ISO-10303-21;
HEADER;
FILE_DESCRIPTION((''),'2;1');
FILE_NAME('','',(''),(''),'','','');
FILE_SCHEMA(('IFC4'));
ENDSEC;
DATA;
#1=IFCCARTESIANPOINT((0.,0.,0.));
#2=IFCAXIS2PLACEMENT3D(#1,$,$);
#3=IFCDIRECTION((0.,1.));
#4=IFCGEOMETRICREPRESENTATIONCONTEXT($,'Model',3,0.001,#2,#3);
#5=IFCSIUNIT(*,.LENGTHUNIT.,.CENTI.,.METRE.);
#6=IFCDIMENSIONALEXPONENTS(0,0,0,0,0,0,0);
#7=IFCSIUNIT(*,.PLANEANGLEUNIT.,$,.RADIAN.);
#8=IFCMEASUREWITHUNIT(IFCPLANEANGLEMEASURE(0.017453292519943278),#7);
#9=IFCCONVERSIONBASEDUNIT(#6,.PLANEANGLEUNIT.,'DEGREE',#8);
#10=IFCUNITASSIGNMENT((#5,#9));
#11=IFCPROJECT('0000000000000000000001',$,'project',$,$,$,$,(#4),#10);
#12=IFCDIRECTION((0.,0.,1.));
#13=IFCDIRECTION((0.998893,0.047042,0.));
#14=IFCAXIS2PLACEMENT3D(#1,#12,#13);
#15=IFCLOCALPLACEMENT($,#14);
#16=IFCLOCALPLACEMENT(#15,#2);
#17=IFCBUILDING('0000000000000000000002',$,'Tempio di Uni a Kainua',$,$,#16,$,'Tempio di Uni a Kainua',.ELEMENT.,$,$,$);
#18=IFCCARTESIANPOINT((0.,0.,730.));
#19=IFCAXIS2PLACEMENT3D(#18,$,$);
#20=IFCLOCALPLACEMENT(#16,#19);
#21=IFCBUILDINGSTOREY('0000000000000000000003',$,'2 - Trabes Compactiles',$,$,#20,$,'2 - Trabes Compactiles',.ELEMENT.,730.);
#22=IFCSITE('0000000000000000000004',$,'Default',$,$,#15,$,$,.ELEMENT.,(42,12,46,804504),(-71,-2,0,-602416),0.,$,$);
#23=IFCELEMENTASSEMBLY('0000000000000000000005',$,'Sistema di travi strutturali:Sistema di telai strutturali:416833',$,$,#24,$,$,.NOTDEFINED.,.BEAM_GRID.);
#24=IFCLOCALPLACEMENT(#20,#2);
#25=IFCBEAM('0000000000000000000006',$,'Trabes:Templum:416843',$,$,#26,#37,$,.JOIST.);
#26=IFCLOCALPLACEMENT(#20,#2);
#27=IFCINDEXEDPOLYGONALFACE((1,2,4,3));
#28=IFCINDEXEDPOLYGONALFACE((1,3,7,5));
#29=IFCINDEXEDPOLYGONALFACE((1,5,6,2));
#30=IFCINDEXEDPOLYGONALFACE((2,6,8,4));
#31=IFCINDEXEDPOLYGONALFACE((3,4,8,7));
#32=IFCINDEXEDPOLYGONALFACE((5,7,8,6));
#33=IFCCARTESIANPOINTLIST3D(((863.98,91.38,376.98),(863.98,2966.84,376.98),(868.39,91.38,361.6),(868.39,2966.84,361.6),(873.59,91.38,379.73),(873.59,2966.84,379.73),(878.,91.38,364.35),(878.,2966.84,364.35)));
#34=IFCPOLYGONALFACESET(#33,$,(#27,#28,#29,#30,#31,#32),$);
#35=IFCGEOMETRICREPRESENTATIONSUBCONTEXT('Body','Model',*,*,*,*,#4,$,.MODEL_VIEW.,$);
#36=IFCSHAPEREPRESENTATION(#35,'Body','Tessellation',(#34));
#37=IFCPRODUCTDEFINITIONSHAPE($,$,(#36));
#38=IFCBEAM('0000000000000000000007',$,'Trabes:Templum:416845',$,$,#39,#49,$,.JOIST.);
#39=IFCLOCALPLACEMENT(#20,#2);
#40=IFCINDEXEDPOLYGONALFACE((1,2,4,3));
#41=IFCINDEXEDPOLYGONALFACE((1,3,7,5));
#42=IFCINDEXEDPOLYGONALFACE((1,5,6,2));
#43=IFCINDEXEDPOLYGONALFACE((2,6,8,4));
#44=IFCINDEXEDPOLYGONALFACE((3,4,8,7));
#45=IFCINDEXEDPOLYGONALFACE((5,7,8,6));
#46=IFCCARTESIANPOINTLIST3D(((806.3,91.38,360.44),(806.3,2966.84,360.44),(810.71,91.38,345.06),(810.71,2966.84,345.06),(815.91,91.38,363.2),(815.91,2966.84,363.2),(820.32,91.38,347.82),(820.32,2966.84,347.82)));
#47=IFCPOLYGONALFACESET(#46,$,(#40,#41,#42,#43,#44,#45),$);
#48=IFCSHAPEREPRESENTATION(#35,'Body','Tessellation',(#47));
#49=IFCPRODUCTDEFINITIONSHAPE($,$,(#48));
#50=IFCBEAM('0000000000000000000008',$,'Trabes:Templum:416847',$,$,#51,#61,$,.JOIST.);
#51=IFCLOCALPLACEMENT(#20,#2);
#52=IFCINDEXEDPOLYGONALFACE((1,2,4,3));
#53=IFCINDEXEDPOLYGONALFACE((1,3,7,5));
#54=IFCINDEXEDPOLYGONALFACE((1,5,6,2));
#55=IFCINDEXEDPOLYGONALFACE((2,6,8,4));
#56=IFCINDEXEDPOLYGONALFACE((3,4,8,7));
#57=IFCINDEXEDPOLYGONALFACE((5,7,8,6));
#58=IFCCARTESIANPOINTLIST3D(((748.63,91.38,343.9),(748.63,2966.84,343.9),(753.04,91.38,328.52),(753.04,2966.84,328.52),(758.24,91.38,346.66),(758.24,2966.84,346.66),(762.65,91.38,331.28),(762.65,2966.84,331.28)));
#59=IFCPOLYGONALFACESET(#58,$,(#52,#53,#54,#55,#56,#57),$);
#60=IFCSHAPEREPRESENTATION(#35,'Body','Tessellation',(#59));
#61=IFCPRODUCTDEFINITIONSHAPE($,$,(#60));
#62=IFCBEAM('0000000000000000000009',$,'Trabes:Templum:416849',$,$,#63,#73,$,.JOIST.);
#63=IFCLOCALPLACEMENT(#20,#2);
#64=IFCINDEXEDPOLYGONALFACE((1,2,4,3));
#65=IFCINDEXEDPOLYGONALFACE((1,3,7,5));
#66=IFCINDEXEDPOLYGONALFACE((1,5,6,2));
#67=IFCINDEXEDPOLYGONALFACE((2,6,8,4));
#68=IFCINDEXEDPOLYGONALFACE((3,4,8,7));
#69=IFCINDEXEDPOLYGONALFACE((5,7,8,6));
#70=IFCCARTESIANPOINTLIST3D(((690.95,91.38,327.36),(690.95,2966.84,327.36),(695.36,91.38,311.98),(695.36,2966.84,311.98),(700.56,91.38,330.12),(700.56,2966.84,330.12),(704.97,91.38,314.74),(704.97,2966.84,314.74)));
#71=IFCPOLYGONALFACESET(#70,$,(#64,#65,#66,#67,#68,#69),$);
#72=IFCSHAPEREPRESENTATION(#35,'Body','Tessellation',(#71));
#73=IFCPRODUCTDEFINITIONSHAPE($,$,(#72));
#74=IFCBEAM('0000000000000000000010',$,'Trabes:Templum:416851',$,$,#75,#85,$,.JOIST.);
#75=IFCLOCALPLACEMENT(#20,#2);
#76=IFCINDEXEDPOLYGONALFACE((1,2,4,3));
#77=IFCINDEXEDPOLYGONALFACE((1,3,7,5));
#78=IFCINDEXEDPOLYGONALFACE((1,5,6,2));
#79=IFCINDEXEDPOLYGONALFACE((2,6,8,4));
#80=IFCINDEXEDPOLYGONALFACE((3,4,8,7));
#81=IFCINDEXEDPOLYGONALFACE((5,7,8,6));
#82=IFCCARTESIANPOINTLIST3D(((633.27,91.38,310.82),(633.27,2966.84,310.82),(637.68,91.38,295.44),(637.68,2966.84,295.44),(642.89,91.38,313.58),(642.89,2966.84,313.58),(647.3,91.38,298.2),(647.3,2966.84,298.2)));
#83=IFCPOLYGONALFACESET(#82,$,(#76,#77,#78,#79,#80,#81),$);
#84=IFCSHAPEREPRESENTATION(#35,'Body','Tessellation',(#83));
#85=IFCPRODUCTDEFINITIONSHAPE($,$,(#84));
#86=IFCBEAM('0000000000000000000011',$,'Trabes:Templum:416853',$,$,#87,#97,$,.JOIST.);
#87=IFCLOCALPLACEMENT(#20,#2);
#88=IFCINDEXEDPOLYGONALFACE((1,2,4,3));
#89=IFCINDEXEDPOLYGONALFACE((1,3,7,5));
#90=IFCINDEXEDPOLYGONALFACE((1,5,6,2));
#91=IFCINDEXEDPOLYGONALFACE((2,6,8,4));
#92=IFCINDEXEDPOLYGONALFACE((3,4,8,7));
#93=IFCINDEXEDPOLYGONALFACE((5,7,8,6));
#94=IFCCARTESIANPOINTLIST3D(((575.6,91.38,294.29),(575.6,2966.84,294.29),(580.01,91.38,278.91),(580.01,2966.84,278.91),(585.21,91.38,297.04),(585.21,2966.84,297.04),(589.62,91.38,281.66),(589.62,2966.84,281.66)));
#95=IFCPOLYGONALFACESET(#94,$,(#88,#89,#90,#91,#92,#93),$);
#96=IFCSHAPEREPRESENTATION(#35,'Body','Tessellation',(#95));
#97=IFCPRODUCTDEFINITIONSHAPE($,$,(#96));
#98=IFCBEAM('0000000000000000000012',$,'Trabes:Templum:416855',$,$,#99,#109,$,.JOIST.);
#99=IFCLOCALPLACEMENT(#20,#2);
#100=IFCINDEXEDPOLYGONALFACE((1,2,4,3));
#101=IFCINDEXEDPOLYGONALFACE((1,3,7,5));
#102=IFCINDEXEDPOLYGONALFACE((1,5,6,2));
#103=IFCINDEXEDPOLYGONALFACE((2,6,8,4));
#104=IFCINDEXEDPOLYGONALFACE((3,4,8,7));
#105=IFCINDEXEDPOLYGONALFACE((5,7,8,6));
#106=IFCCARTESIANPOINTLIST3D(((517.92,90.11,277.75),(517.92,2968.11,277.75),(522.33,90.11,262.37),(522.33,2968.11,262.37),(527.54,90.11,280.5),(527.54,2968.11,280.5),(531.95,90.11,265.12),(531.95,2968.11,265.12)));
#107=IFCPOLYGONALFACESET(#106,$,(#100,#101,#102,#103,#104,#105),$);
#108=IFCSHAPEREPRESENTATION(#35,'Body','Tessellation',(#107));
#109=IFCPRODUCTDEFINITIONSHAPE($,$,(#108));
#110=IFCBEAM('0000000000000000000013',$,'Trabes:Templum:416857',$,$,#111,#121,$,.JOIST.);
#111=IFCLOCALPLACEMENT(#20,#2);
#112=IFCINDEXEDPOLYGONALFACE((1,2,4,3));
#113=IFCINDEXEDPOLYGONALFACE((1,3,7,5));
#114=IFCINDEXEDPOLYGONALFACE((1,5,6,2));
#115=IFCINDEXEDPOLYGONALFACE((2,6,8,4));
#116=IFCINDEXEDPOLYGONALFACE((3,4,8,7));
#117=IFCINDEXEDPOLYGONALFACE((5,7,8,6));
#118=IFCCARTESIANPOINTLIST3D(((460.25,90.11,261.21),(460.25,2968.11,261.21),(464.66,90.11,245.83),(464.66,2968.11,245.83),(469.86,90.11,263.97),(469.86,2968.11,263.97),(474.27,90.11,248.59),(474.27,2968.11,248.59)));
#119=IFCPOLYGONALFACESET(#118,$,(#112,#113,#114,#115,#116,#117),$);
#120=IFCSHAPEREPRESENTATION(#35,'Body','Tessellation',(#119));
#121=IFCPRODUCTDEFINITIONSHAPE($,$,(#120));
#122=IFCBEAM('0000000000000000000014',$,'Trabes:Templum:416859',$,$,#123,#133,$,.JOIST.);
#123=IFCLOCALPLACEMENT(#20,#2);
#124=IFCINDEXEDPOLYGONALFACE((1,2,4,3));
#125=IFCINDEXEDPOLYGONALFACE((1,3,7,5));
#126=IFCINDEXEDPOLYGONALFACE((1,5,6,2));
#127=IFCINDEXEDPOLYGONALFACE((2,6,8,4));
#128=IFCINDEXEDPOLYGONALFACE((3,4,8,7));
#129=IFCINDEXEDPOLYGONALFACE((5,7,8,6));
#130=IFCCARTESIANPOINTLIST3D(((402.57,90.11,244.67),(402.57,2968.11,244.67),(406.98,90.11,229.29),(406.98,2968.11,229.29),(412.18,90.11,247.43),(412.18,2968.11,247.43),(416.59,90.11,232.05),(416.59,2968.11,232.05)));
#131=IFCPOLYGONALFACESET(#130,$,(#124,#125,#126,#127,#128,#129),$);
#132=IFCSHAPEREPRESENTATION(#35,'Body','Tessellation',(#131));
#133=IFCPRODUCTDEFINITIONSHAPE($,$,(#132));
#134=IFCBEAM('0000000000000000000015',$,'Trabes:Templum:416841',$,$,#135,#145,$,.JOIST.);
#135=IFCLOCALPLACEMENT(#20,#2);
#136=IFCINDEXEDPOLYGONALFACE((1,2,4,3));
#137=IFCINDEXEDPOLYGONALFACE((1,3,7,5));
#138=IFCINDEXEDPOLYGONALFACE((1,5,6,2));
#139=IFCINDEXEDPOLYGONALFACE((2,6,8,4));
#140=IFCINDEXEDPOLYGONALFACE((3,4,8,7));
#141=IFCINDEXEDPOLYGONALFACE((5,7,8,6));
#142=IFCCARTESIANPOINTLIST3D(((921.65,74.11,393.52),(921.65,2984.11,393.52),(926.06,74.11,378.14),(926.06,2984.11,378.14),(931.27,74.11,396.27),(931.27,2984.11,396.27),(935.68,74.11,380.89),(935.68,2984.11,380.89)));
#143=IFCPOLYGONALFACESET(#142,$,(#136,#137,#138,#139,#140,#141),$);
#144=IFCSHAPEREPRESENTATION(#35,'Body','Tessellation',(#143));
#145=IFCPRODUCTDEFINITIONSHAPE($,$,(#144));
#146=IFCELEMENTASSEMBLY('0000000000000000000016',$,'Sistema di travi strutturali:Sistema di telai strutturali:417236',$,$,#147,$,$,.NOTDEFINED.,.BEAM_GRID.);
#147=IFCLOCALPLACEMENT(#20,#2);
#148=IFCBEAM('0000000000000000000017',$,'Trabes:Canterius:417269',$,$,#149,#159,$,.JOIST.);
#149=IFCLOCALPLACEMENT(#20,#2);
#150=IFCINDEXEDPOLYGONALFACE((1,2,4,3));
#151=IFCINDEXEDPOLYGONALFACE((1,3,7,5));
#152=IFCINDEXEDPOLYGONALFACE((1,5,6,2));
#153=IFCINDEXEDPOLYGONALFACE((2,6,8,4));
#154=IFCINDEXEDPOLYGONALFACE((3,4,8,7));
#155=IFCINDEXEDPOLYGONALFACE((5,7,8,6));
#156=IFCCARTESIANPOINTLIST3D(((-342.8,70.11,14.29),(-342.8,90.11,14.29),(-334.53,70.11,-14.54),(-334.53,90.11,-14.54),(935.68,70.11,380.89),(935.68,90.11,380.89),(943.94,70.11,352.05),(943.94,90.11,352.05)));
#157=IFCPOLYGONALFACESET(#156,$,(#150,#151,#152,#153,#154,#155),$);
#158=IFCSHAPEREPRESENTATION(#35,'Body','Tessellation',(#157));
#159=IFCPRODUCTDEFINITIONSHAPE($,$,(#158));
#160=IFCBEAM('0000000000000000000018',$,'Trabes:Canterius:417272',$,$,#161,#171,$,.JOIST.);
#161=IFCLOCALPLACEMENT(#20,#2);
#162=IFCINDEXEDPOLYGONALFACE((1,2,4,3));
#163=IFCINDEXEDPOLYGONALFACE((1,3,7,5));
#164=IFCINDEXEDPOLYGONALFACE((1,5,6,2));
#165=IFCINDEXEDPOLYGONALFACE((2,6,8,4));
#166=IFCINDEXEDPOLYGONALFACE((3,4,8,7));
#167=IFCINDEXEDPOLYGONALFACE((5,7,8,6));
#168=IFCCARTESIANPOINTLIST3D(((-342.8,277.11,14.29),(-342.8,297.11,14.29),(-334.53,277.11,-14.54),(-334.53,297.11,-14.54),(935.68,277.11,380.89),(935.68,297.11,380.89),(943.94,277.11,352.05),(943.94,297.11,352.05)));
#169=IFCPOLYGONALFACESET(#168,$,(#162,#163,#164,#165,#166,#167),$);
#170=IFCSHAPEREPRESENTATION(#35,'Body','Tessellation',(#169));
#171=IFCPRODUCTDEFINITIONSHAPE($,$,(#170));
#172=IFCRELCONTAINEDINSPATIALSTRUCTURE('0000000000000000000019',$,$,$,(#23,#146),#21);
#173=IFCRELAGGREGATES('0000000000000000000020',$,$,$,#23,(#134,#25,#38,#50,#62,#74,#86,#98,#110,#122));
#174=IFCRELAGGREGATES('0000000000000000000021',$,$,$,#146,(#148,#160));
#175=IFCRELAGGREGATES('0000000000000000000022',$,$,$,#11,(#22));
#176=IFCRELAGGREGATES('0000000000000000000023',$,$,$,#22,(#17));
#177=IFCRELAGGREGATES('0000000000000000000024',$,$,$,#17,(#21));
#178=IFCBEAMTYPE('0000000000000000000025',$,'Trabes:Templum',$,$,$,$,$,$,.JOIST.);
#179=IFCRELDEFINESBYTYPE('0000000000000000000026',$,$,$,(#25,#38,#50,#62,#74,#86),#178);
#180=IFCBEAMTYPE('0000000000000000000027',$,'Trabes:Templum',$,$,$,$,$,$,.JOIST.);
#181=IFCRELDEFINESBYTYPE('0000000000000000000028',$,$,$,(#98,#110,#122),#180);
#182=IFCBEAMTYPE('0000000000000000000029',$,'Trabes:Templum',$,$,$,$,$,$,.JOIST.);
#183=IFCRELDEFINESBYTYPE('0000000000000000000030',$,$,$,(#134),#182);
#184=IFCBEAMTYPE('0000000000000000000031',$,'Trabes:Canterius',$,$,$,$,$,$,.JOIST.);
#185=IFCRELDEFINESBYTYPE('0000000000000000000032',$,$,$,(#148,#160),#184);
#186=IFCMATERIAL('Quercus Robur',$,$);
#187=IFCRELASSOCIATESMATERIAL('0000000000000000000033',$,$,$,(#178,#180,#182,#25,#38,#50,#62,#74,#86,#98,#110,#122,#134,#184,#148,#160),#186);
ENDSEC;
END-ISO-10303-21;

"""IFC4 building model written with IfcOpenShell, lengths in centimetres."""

from ifc_helpers import new_model, entity, si_unit, converted_unit, direction, frame, frame_2d, origin, origin_2d_with_axis, place, context, subcontext, project, spatial, rectangle, extrude, source, transform, mapped, material, material_profile, profile_set, profile_usage, type_object, type_shapes, element, aggregate, save


model = new_model("IFC4")

# Units and contexts
model_context = context("Model", 3, precision=0.001, world=origin(), true_north=direction((0.0, 1.0)))
body_context = subcontext(model_context, "Body", "Model", "MODEL_VIEW")
ifc_project = project(units=[si_unit("LENGTHUNIT", "METRE", prefix="CENTI"), converted_unit("PLANEANGLEUNIT", "DEGREE", entity("IfcPlaneAngleMeasure", 0.017453292519943278), si_unit("PLANEANGLEUNIT", "RADIAN"), dimensions=[0, 0, 0, 0, 0, 0, 0])], contexts=[model_context])

# Site, building, storey
site_placement = place(None, frame((0.0, 0.0, 0.0), z_axis=(0.0, 0.0, 1.0), x_axis=(0.998893, 0.047042, 0.0)))
site = spatial("IfcSite", under=ifc_project, at=site_placement, Name="Default", CompositionType="ELEMENT", RefLatitude=(42, 12, 46, 804504), RefLongitude=(-71, -2, 0, -602416), RefElevation=0.0)
building_placement = place(site_placement, origin())
building = spatial("IfcBuilding", under=site, at=building_placement, Name="Tempio di Uni a Kainua", LongName="Tempio di Uni a Kainua", CompositionType="ELEMENT")
storey_placement = place(building_placement, frame((0.0, 0.0, 730.0)))
storey = spatial("IfcBuildingStorey", under=building, at=storey_placement, Name="2 - Trabes Compactiles", LongName="2 - Trabes Compactiles", CompositionType="ELEMENT", Elevation=730.0)

# Shared definitions
ifc_material = material(Name="Quercus Robur")

# Element assemblies, beams
ifc_material_profile_1 = material_profile(ifc_material, rectangle(XDim=2590.0, YDim=20.0, at=origin_2d_with_axis()), Name="Canterius")
ifc_profile_set_1 = profile_set([ifc_material_profile_1], Name="Canterius")
ifc_profile_usage_1 = profile_usage(ifc_profile_set_1, cardinal=8)
assembly_1_placement = place(storey_placement, origin())
assembly_1 = element("IfcElementAssembly", 1, at=assembly_1_placement, inside=storey, Name="Sistema di travi strutturali:Sistema di telai strutturali:416833", AssemblyPlace="NOTDEFINED", PredefinedType="BEAM_GRID")
ifc_material_profile_2 = material_profile(ifc_material, rectangle(XDim=2875.46, YDim=10.0, at=origin_2d_with_axis()), Name="Templum")
ifc_profile_set_2 = profile_set([ifc_material_profile_2], Name="Templum")
ifc_profile_usage_2 = profile_usage(ifc_profile_set_2, cardinal=2)
beam_type_1 = type_object("IfcBeamType", Name="Trabes:Templum", PredefinedType="JOIST", material=ifc_profile_set_2)
shared_shape_1 = source(origin(), body_context, "Body", "SweptSolid", [
    extrude(rectangle(XDim=2875.46, YDim=10.0, at=origin_2d_with_axis()), frame((0.0, 0.0, -8.0)), (0.0, 0.0, 1.0), 16.0),
])
type_shapes(beam_type_1, [shared_shape_1])
beam_1_placement = place(assembly_1_placement, frame((870.99, 1529.11, 370.67), z_axis=(-0.275637, 0.0, 0.961262), x_axis=(0.0, 1.0, 0.0)))
beam_1 = element("IfcBeam", 2, at=beam_1_placement, type_object=beam_type_1, material=ifc_profile_usage_2, Name="Trabes:Templum:416843", PredefinedType="JOIST", context=body_context, shape_type="MappedRepresentation", body=[
    mapped(shared_shape_1, transform((0.0, 0.0, 0.0), scale=1.0)),
])
beam_2_placement = place(assembly_1_placement, frame((813.31, 1529.11, 354.13), z_axis=(-0.275637, 0.0, 0.961262), x_axis=(0.0, 1.0, 0.0)))
beam_2 = element("IfcBeam", 3, at=beam_2_placement, type_object=beam_type_1, material=ifc_profile_usage_2, Name="Trabes:Templum:416845", PredefinedType="JOIST", context=body_context, shape_type="MappedRepresentation", body=[
    mapped(shared_shape_1, transform((0.0, 0.0, 0.0), scale=1.0)),
])
beam_3_placement = place(assembly_1_placement, frame((755.64, 1529.11, 337.59), z_axis=(-0.275637, 0.0, 0.961262), x_axis=(0.0, 1.0, 0.0)))
beam_3 = element("IfcBeam", 4, at=beam_3_placement, type_object=beam_type_1, material=ifc_profile_usage_2, Name="Trabes:Templum:416847", PredefinedType="JOIST", context=body_context, shape_type="MappedRepresentation", body=[
    mapped(shared_shape_1, transform((0.0, 0.0, 0.0), scale=1.0)),
])
beam_4_placement = place(assembly_1_placement, frame((697.96, 1529.11, 321.05), z_axis=(-0.275637, 0.0, 0.961262), x_axis=(0.0, 1.0, 0.0)))
beam_4 = element("IfcBeam", 5, at=beam_4_placement, type_object=beam_type_1, material=ifc_profile_usage_2, Name="Trabes:Templum:416849", PredefinedType="JOIST", context=body_context, shape_type="MappedRepresentation", body=[
    mapped(shared_shape_1, transform((0.0, 0.0, 0.0), scale=1.0)),
])
beam_5_placement = place(assembly_1_placement, frame((640.29, 1529.11, 304.51), z_axis=(-0.275637, 0.0, 0.961262), x_axis=(0.0, 1.0, 0.0)))
beam_5 = element("IfcBeam", 6, at=beam_5_placement, type_object=beam_type_1, material=ifc_profile_usage_2, Name="Trabes:Templum:416851", PredefinedType="JOIST", context=body_context, shape_type="MappedRepresentation", body=[
    mapped(shared_shape_1, transform((0.0, 0.0, 0.0), scale=1.0)),
])
beam_6_placement = place(assembly_1_placement, frame((582.61, 1529.11, 287.97), z_axis=(-0.275637, 0.0, 0.961262), x_axis=(0.0, 1.0, 0.0)))
beam_6 = element("IfcBeam", 7, at=beam_6_placement, type_object=beam_type_1, material=ifc_profile_usage_2, Name="Trabes:Templum:416853", PredefinedType="JOIST", context=body_context, shape_type="MappedRepresentation", body=[
    mapped(shared_shape_1, transform((0.0, 0.0, 0.0), scale=1.0)),
])
beam_type_2 = type_object("IfcBeamType", Name="Trabes:Templum", PredefinedType="JOIST", material=ifc_profile_set_2)
shared_shape_2 = source(origin(), body_context, "Body", "SweptSolid", [
    extrude(rectangle(XDim=2878.0, YDim=10.0, at=frame_2d((0.0, 0.0), x_axis=(1.0, 0.0))), frame((0.0, 0.0, -8.0)), (0.0, 0.0, 1.0), 16.0),
])
type_shapes(beam_type_2, [shared_shape_2])
beam_7_placement = place(assembly_1_placement, frame((524.93, 1529.11, 271.44), z_axis=(-0.275637, 0.0, 0.961262), x_axis=(0.0, 1.0, 0.0)))
beam_7 = element("IfcBeam", 8, at=beam_7_placement, type_object=beam_type_2, material=ifc_profile_usage_2, Name="Trabes:Templum:416855", PredefinedType="JOIST", context=body_context, shape_type="MappedRepresentation", body=[
    mapped(shared_shape_2, transform((0.0, 0.0, 0.0), scale=1.0)),
])
beam_8_placement = place(assembly_1_placement, frame((467.26, 1529.11, 254.9), z_axis=(-0.275637, 0.0, 0.961262), x_axis=(0.0, 1.0, 0.0)))
beam_8 = element("IfcBeam", 9, at=beam_8_placement, type_object=beam_type_2, material=ifc_profile_usage_2, Name="Trabes:Templum:416857", PredefinedType="JOIST", context=body_context, shape_type="MappedRepresentation", body=[
    mapped(shared_shape_2, transform((0.0, 0.0, 0.0), scale=1.0)),
])
beam_9_placement = place(assembly_1_placement, frame((409.58, 1529.11, 238.36), z_axis=(-0.275637, 0.0, 0.961262), x_axis=(0.0, 1.0, 0.0)))
beam_9 = element("IfcBeam", 10, at=beam_9_placement, type_object=beam_type_2, material=ifc_profile_usage_2, Name="Trabes:Templum:416859", PredefinedType="JOIST", context=body_context, shape_type="MappedRepresentation", body=[
    mapped(shared_shape_2, transform((0.0, 0.0, 0.0), scale=1.0)),
])
beam_type_3 = type_object("IfcBeamType", Name="Trabes:Templum", PredefinedType="JOIST", material=ifc_profile_set_2)
shared_shape_3 = source(origin(), body_context, "Body", "SweptSolid", [
    extrude(rectangle(XDim=2910.0, YDim=10.0, at=origin_2d_with_axis()), frame((0.0, 0.0, -8.0)), (0.0, 0.0, 1.0), 16.0),
])
type_shapes(beam_type_3, [shared_shape_3])
beam_10_placement = place(assembly_1_placement, frame((928.66, 1529.11, 387.2), z_axis=(-0.275637, 0.0, 0.961262), x_axis=(0.0, 1.0, 0.0)))
beam_10 = element("IfcBeam", 11, at=beam_10_placement, type_object=beam_type_3, material=ifc_profile_usage_2, Name="Trabes:Templum:416841", PredefinedType="JOIST", context=body_context, shape_type="MappedRepresentation", body=[
    mapped(shared_shape_3, transform((0.0, 0.0, 0.0), scale=1.0)),
])
aggregate(assembly_1, [beam_10, beam_1, beam_2, beam_3, beam_4, beam_5, beam_6, beam_7, beam_8, beam_9])
assembly_2_placement = place(storey_placement, origin())
assembly_2 = element("IfcElementAssembly", 12, at=assembly_2_placement, inside=storey, Name="Sistema di travi strutturali:Sistema di telai strutturali:417236", AssemblyPlace="NOTDEFINED", PredefinedType="BEAM_GRID")
beam_type_4 = type_object("IfcBeamType", Name="Trabes:Canterius", PredefinedType="JOIST", material=ifc_profile_set_1)
shared_shape_4 = source(origin(), body_context, "Body", "SweptSolid", [
    extrude(rectangle(XDim=1330.0, YDim=20.0, at=origin_2d_with_axis()), frame((0.0, 0.0, -15.0)), (0.0, 0.0, 1.0), 30.0),
])
type_shapes(beam_type_4, [shared_shape_4])
beam_11_placement = place(assembly_2_placement, frame((300.57, 80.11, 183.17), z_axis=(-0.275637, 0.0, 0.961262), x_axis=(0.961262, 0.0, 0.275637)))
beam_11 = element("IfcBeam", 13, at=beam_11_placement, type_object=beam_type_4, material=ifc_profile_usage_1, Name="Trabes:Canterius:417269", PredefinedType="JOIST", context=body_context, shape_type="MappedRepresentation", body=[
    mapped(shared_shape_4, transform((0.0, 0.0, 0.0), scale=1.0)),
])
beam_12_placement = place(assembly_2_placement, frame((300.57, 287.11, 183.17), z_axis=(-0.275637, 0.0, 0.961262), x_axis=(0.961262, 0.0, 0.275637)))
beam_12 = element("IfcBeam", 14, at=beam_12_placement, type_object=beam_type_4, material=ifc_profile_usage_1, Name="Trabes:Canterius:417272", PredefinedType="JOIST", context=body_context, shape_type="MappedRepresentation", body=[
    mapped(shared_shape_4, transform((0.0, 0.0, 0.0), scale=1.0)),
])
aggregate(assembly_2, [beam_11, beam_12])

save(model, "model.ifc")
